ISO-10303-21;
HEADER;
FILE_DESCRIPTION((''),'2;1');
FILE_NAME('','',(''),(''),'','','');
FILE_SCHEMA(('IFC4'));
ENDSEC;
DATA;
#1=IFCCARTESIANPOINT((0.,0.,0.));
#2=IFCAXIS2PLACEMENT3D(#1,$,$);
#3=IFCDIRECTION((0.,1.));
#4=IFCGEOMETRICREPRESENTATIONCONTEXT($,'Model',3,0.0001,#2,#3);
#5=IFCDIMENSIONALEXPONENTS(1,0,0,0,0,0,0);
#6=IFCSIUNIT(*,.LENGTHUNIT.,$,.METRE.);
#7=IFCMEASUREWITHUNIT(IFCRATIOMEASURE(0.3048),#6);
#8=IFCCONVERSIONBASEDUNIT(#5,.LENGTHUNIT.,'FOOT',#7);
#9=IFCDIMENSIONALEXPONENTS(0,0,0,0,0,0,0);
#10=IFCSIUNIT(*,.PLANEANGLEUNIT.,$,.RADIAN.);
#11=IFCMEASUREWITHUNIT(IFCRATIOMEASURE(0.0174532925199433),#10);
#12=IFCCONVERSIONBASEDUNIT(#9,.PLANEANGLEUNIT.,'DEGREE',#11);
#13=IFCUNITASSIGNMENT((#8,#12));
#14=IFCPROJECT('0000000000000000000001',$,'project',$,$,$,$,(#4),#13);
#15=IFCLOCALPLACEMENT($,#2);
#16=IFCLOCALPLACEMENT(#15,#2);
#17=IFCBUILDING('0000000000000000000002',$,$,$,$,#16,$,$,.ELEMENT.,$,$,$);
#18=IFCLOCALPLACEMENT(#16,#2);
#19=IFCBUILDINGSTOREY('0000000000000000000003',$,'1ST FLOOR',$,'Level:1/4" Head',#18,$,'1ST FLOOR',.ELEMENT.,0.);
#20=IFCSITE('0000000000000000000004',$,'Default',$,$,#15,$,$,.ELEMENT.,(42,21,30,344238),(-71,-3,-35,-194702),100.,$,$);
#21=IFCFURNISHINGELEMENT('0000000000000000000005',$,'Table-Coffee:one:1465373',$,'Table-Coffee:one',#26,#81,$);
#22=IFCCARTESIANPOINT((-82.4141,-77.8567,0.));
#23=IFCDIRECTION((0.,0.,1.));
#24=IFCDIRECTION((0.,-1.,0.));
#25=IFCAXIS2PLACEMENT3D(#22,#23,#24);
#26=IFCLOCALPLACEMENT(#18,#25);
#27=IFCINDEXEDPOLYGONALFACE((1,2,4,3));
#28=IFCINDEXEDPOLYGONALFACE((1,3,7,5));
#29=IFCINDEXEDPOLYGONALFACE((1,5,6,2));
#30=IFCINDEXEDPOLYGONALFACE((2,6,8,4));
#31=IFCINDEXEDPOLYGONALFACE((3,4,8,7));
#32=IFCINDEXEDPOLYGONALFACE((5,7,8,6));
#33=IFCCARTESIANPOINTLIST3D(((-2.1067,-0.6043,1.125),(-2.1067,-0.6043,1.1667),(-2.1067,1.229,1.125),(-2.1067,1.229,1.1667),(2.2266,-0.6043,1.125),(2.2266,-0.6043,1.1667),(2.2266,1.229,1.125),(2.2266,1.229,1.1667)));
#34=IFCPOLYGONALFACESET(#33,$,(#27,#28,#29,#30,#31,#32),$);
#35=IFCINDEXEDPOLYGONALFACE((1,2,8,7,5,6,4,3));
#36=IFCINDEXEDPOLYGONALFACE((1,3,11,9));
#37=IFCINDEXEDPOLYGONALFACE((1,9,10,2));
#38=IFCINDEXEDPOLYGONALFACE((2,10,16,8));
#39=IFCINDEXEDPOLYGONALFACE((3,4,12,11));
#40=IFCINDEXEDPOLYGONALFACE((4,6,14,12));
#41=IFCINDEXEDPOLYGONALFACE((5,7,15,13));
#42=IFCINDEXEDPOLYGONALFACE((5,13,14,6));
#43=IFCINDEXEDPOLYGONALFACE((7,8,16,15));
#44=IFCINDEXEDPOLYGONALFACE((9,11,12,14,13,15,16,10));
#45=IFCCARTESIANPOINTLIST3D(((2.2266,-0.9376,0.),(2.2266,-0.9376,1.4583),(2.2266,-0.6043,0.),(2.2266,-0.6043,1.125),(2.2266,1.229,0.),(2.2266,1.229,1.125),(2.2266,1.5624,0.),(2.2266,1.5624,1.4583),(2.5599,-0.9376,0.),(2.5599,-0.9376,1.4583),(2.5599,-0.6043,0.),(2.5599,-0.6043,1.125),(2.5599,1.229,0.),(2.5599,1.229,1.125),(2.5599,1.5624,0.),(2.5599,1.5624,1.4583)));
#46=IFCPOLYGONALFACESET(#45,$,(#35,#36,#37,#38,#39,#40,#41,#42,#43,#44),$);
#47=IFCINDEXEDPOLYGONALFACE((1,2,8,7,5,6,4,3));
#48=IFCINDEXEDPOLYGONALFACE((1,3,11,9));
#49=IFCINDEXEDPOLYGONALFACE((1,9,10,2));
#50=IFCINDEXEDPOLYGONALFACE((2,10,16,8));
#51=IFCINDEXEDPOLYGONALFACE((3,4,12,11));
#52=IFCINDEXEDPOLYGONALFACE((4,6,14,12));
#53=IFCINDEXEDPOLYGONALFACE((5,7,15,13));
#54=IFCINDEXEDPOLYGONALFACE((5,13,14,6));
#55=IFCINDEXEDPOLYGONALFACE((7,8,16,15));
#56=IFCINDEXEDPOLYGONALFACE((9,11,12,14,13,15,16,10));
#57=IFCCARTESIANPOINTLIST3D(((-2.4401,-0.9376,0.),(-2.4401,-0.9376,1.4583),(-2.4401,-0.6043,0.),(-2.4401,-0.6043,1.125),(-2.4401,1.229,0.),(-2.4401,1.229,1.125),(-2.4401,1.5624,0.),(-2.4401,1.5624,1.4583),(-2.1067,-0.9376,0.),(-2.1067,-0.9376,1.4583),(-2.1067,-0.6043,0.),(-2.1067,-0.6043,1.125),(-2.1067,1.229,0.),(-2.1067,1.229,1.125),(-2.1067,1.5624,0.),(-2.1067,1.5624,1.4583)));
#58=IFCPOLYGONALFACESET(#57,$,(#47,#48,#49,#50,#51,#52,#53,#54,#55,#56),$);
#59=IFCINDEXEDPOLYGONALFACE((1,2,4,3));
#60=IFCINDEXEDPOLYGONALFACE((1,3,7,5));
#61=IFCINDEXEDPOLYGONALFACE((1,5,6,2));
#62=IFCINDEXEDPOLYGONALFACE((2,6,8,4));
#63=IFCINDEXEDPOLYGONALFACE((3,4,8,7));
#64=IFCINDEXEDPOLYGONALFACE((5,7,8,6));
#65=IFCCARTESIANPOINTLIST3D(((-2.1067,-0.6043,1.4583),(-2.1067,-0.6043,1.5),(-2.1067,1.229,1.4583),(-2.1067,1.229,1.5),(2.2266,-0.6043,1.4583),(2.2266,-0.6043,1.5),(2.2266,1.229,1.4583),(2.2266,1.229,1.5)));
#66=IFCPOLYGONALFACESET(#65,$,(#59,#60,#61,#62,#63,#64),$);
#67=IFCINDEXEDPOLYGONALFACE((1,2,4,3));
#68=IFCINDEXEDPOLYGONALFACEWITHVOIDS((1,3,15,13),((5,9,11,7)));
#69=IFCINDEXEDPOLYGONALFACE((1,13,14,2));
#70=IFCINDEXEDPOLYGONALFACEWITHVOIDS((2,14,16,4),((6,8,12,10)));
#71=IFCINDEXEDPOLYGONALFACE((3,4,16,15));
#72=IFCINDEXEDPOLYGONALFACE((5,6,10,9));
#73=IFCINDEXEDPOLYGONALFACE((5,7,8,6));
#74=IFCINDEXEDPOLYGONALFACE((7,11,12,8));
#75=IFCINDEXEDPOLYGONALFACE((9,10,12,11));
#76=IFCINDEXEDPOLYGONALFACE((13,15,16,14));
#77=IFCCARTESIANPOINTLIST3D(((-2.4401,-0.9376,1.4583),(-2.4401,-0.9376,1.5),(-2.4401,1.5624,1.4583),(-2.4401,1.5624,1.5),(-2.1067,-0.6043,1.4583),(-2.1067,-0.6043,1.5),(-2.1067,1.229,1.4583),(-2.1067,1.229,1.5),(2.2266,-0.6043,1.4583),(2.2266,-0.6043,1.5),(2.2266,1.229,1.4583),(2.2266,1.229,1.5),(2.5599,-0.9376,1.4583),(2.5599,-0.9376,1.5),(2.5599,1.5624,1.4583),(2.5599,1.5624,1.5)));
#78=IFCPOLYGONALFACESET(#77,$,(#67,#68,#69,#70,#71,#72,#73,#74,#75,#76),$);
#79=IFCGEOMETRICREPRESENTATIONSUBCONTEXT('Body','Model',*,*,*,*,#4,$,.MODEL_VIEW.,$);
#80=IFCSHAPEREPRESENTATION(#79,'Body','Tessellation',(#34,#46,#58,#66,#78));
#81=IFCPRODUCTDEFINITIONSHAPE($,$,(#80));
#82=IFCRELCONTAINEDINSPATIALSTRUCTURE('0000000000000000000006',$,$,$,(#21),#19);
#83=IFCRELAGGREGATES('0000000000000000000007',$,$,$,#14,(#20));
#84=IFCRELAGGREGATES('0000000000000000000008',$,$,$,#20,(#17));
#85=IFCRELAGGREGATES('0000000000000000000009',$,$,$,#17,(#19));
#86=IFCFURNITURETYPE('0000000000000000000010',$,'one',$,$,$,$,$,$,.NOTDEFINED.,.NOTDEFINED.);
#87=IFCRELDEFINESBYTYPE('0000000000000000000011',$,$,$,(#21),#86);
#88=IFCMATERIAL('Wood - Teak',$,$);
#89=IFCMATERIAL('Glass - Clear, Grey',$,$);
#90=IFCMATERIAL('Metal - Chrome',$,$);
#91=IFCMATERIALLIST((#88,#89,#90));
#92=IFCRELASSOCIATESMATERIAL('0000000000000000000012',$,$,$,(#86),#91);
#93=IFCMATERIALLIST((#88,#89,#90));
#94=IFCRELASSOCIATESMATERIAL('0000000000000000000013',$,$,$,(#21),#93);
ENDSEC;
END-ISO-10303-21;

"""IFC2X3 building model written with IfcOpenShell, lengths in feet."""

from ifc_helpers import new_model, entity, si_unit, converted_unit, direction, frame, origin, origin_2d_with_axis, place, context, subcontext, project, spatial, polyline, rectangle, outline, extrude, source, transform, mapped, material, material_list, type_object, type_shapes, element, save


model = new_model("IFC2X3")

# Units and contexts
model_context = context("Model", 3, precision=0.0001, world=origin(), true_north=direction((0.0, 1.0)))
body_context = subcontext(model_context, "Body", "Model", "MODEL_VIEW")
ifc_project = project(units=[converted_unit("LENGTHUNIT", "FOOT", entity("IfcRatioMeasure", 0.3048), si_unit("LENGTHUNIT", "METRE"), dimensions=[1, 0, 0, 0, 0, 0, 0]), converted_unit("PLANEANGLEUNIT", "DEGREE", entity("IfcRatioMeasure", 0.0174532925199433), si_unit("PLANEANGLEUNIT", "RADIAN"), dimensions=[0, 0, 0, 0, 0, 0, 0])], contexts=[model_context])

# Site, building, storey
site_placement = place(None, origin())
site = spatial("IfcSite", under=ifc_project, at=site_placement, Name="Default", CompositionType="ELEMENT", RefLatitude=(42, 21, 30, 344238), RefLongitude=(-71, -3, -35, -194702), RefElevation=100.0)
building_placement = place(site_placement, origin())
building = spatial("IfcBuilding", under=site, at=building_placement, CompositionType="ELEMENT")
storey_placement = place(building_placement, origin())
storey = spatial("IfcBuildingStorey", under=building, at=storey_placement, Name="1ST FLOOR", ObjectType="Level:1/4\" Head", LongName="1ST FLOOR", CompositionType="ELEMENT", Elevation=0.0)

# Furnishing element
ifc_material_1 = material(Name="Wood - Teak")
ifc_material_2 = material(Name="Glass - Clear, Grey")
ifc_material_3 = material(Name="Metal - Chrome")
ifc_material_list_1 = material_list([ifc_material_1, ifc_material_2, ifc_material_3])
ifc_material_list_2 = material_list([ifc_material_1, ifc_material_2, ifc_material_3])
furniture_type_1 = type_object("IfcFurnitureType", Name="one", material=ifc_material_list_2)
shared_shape_1 = source(origin(), body_context, "Body", "SweptSolid", [
    extrude(rectangle(XDim=4.3333, YDim=1.8333, at=origin_2d_with_axis()), frame((0.0599, 0.3124, 1.125), z_axis=(0.0, 0.0, 1.0), x_axis=(-1.0, 0.0, 0.0)), (0.0, 0.0, 1.0), 0.0417),
    extrude(outline(polyline([(-0.6458, -1.25), (0.8125, -1.25), (0.8125, 1.25), (-0.6458, 1.25), (-0.6458, 0.9167), (0.4792, 0.9167), (0.4792, -0.9167), (-0.6458, -0.9167), (-0.6458, -1.25)])), frame((2.2266, 0.3124, 0.6458), z_axis=(1.0, 0.0, 0.0), x_axis=(0.0, 0.0, 1.0)), (0.0, 0.0, 1.0), 0.3333),
    extrude(outline(polyline([(-1.25, -0.8125), (1.25, -0.8125), (1.25, 0.6458), (0.9167, 0.6458), (0.9167, -0.4792), (-0.9167, -0.4792), (-0.9167, 0.6458), (-1.25, 0.6458), (-1.25, -0.8125)])), frame((-2.4401, 0.3124, 0.6458), z_axis=(1.0, 0.0, 0.0), x_axis=(0.0, -1.0, 0.0)), (0.0, 0.0, 1.0), 0.3333),
    extrude(rectangle(XDim=4.3333, YDim=1.8333, at=origin_2d_with_axis()), frame((0.0599, 0.3124, 1.4583), z_axis=(0.0, 0.0, 1.0), x_axis=(-1.0, 0.0, 0.0)), (0.0, 0.0, 1.0), 0.0417),
    extrude(outline(polyline([(-2.5, -1.25), (2.5, -1.25), (2.5, 1.25), (-2.5, 1.25), (-2.5, -1.25)]), holes=[polyline([(-2.1667, -0.9167), (-2.1667, 0.9167), (2.1667, 0.9167), (2.1667, -0.9167), (-2.1667, -0.9167)])]), frame((0.0599, 0.3124, 1.4583), z_axis=(0.0, 0.0, 1.0), x_axis=(-1.0, 0.0, 0.0)), (0.0, 0.0, 1.0), 0.0417),
])
type_shapes(furniture_type_1, [shared_shape_1])
furnishing_1_placement = place(storey_placement, frame((-82.4141, -77.8567, 0.0), z_axis=(0.0, 0.0, 1.0), x_axis=(0.0, -1.0, 0.0)))
element("IfcFurnishingElement", 1, at=furnishing_1_placement, inside=storey, type_object=furniture_type_1, material=ifc_material_list_1, Name="Table-Coffee:one:1465373", ObjectType="Table-Coffee:one", context=body_context, shape_type="MappedRepresentation", body=[
    mapped(shared_shape_1, transform((0.0, 0.0, 0.0), scale=1.0)),
])

save(model, "model.ifc")
